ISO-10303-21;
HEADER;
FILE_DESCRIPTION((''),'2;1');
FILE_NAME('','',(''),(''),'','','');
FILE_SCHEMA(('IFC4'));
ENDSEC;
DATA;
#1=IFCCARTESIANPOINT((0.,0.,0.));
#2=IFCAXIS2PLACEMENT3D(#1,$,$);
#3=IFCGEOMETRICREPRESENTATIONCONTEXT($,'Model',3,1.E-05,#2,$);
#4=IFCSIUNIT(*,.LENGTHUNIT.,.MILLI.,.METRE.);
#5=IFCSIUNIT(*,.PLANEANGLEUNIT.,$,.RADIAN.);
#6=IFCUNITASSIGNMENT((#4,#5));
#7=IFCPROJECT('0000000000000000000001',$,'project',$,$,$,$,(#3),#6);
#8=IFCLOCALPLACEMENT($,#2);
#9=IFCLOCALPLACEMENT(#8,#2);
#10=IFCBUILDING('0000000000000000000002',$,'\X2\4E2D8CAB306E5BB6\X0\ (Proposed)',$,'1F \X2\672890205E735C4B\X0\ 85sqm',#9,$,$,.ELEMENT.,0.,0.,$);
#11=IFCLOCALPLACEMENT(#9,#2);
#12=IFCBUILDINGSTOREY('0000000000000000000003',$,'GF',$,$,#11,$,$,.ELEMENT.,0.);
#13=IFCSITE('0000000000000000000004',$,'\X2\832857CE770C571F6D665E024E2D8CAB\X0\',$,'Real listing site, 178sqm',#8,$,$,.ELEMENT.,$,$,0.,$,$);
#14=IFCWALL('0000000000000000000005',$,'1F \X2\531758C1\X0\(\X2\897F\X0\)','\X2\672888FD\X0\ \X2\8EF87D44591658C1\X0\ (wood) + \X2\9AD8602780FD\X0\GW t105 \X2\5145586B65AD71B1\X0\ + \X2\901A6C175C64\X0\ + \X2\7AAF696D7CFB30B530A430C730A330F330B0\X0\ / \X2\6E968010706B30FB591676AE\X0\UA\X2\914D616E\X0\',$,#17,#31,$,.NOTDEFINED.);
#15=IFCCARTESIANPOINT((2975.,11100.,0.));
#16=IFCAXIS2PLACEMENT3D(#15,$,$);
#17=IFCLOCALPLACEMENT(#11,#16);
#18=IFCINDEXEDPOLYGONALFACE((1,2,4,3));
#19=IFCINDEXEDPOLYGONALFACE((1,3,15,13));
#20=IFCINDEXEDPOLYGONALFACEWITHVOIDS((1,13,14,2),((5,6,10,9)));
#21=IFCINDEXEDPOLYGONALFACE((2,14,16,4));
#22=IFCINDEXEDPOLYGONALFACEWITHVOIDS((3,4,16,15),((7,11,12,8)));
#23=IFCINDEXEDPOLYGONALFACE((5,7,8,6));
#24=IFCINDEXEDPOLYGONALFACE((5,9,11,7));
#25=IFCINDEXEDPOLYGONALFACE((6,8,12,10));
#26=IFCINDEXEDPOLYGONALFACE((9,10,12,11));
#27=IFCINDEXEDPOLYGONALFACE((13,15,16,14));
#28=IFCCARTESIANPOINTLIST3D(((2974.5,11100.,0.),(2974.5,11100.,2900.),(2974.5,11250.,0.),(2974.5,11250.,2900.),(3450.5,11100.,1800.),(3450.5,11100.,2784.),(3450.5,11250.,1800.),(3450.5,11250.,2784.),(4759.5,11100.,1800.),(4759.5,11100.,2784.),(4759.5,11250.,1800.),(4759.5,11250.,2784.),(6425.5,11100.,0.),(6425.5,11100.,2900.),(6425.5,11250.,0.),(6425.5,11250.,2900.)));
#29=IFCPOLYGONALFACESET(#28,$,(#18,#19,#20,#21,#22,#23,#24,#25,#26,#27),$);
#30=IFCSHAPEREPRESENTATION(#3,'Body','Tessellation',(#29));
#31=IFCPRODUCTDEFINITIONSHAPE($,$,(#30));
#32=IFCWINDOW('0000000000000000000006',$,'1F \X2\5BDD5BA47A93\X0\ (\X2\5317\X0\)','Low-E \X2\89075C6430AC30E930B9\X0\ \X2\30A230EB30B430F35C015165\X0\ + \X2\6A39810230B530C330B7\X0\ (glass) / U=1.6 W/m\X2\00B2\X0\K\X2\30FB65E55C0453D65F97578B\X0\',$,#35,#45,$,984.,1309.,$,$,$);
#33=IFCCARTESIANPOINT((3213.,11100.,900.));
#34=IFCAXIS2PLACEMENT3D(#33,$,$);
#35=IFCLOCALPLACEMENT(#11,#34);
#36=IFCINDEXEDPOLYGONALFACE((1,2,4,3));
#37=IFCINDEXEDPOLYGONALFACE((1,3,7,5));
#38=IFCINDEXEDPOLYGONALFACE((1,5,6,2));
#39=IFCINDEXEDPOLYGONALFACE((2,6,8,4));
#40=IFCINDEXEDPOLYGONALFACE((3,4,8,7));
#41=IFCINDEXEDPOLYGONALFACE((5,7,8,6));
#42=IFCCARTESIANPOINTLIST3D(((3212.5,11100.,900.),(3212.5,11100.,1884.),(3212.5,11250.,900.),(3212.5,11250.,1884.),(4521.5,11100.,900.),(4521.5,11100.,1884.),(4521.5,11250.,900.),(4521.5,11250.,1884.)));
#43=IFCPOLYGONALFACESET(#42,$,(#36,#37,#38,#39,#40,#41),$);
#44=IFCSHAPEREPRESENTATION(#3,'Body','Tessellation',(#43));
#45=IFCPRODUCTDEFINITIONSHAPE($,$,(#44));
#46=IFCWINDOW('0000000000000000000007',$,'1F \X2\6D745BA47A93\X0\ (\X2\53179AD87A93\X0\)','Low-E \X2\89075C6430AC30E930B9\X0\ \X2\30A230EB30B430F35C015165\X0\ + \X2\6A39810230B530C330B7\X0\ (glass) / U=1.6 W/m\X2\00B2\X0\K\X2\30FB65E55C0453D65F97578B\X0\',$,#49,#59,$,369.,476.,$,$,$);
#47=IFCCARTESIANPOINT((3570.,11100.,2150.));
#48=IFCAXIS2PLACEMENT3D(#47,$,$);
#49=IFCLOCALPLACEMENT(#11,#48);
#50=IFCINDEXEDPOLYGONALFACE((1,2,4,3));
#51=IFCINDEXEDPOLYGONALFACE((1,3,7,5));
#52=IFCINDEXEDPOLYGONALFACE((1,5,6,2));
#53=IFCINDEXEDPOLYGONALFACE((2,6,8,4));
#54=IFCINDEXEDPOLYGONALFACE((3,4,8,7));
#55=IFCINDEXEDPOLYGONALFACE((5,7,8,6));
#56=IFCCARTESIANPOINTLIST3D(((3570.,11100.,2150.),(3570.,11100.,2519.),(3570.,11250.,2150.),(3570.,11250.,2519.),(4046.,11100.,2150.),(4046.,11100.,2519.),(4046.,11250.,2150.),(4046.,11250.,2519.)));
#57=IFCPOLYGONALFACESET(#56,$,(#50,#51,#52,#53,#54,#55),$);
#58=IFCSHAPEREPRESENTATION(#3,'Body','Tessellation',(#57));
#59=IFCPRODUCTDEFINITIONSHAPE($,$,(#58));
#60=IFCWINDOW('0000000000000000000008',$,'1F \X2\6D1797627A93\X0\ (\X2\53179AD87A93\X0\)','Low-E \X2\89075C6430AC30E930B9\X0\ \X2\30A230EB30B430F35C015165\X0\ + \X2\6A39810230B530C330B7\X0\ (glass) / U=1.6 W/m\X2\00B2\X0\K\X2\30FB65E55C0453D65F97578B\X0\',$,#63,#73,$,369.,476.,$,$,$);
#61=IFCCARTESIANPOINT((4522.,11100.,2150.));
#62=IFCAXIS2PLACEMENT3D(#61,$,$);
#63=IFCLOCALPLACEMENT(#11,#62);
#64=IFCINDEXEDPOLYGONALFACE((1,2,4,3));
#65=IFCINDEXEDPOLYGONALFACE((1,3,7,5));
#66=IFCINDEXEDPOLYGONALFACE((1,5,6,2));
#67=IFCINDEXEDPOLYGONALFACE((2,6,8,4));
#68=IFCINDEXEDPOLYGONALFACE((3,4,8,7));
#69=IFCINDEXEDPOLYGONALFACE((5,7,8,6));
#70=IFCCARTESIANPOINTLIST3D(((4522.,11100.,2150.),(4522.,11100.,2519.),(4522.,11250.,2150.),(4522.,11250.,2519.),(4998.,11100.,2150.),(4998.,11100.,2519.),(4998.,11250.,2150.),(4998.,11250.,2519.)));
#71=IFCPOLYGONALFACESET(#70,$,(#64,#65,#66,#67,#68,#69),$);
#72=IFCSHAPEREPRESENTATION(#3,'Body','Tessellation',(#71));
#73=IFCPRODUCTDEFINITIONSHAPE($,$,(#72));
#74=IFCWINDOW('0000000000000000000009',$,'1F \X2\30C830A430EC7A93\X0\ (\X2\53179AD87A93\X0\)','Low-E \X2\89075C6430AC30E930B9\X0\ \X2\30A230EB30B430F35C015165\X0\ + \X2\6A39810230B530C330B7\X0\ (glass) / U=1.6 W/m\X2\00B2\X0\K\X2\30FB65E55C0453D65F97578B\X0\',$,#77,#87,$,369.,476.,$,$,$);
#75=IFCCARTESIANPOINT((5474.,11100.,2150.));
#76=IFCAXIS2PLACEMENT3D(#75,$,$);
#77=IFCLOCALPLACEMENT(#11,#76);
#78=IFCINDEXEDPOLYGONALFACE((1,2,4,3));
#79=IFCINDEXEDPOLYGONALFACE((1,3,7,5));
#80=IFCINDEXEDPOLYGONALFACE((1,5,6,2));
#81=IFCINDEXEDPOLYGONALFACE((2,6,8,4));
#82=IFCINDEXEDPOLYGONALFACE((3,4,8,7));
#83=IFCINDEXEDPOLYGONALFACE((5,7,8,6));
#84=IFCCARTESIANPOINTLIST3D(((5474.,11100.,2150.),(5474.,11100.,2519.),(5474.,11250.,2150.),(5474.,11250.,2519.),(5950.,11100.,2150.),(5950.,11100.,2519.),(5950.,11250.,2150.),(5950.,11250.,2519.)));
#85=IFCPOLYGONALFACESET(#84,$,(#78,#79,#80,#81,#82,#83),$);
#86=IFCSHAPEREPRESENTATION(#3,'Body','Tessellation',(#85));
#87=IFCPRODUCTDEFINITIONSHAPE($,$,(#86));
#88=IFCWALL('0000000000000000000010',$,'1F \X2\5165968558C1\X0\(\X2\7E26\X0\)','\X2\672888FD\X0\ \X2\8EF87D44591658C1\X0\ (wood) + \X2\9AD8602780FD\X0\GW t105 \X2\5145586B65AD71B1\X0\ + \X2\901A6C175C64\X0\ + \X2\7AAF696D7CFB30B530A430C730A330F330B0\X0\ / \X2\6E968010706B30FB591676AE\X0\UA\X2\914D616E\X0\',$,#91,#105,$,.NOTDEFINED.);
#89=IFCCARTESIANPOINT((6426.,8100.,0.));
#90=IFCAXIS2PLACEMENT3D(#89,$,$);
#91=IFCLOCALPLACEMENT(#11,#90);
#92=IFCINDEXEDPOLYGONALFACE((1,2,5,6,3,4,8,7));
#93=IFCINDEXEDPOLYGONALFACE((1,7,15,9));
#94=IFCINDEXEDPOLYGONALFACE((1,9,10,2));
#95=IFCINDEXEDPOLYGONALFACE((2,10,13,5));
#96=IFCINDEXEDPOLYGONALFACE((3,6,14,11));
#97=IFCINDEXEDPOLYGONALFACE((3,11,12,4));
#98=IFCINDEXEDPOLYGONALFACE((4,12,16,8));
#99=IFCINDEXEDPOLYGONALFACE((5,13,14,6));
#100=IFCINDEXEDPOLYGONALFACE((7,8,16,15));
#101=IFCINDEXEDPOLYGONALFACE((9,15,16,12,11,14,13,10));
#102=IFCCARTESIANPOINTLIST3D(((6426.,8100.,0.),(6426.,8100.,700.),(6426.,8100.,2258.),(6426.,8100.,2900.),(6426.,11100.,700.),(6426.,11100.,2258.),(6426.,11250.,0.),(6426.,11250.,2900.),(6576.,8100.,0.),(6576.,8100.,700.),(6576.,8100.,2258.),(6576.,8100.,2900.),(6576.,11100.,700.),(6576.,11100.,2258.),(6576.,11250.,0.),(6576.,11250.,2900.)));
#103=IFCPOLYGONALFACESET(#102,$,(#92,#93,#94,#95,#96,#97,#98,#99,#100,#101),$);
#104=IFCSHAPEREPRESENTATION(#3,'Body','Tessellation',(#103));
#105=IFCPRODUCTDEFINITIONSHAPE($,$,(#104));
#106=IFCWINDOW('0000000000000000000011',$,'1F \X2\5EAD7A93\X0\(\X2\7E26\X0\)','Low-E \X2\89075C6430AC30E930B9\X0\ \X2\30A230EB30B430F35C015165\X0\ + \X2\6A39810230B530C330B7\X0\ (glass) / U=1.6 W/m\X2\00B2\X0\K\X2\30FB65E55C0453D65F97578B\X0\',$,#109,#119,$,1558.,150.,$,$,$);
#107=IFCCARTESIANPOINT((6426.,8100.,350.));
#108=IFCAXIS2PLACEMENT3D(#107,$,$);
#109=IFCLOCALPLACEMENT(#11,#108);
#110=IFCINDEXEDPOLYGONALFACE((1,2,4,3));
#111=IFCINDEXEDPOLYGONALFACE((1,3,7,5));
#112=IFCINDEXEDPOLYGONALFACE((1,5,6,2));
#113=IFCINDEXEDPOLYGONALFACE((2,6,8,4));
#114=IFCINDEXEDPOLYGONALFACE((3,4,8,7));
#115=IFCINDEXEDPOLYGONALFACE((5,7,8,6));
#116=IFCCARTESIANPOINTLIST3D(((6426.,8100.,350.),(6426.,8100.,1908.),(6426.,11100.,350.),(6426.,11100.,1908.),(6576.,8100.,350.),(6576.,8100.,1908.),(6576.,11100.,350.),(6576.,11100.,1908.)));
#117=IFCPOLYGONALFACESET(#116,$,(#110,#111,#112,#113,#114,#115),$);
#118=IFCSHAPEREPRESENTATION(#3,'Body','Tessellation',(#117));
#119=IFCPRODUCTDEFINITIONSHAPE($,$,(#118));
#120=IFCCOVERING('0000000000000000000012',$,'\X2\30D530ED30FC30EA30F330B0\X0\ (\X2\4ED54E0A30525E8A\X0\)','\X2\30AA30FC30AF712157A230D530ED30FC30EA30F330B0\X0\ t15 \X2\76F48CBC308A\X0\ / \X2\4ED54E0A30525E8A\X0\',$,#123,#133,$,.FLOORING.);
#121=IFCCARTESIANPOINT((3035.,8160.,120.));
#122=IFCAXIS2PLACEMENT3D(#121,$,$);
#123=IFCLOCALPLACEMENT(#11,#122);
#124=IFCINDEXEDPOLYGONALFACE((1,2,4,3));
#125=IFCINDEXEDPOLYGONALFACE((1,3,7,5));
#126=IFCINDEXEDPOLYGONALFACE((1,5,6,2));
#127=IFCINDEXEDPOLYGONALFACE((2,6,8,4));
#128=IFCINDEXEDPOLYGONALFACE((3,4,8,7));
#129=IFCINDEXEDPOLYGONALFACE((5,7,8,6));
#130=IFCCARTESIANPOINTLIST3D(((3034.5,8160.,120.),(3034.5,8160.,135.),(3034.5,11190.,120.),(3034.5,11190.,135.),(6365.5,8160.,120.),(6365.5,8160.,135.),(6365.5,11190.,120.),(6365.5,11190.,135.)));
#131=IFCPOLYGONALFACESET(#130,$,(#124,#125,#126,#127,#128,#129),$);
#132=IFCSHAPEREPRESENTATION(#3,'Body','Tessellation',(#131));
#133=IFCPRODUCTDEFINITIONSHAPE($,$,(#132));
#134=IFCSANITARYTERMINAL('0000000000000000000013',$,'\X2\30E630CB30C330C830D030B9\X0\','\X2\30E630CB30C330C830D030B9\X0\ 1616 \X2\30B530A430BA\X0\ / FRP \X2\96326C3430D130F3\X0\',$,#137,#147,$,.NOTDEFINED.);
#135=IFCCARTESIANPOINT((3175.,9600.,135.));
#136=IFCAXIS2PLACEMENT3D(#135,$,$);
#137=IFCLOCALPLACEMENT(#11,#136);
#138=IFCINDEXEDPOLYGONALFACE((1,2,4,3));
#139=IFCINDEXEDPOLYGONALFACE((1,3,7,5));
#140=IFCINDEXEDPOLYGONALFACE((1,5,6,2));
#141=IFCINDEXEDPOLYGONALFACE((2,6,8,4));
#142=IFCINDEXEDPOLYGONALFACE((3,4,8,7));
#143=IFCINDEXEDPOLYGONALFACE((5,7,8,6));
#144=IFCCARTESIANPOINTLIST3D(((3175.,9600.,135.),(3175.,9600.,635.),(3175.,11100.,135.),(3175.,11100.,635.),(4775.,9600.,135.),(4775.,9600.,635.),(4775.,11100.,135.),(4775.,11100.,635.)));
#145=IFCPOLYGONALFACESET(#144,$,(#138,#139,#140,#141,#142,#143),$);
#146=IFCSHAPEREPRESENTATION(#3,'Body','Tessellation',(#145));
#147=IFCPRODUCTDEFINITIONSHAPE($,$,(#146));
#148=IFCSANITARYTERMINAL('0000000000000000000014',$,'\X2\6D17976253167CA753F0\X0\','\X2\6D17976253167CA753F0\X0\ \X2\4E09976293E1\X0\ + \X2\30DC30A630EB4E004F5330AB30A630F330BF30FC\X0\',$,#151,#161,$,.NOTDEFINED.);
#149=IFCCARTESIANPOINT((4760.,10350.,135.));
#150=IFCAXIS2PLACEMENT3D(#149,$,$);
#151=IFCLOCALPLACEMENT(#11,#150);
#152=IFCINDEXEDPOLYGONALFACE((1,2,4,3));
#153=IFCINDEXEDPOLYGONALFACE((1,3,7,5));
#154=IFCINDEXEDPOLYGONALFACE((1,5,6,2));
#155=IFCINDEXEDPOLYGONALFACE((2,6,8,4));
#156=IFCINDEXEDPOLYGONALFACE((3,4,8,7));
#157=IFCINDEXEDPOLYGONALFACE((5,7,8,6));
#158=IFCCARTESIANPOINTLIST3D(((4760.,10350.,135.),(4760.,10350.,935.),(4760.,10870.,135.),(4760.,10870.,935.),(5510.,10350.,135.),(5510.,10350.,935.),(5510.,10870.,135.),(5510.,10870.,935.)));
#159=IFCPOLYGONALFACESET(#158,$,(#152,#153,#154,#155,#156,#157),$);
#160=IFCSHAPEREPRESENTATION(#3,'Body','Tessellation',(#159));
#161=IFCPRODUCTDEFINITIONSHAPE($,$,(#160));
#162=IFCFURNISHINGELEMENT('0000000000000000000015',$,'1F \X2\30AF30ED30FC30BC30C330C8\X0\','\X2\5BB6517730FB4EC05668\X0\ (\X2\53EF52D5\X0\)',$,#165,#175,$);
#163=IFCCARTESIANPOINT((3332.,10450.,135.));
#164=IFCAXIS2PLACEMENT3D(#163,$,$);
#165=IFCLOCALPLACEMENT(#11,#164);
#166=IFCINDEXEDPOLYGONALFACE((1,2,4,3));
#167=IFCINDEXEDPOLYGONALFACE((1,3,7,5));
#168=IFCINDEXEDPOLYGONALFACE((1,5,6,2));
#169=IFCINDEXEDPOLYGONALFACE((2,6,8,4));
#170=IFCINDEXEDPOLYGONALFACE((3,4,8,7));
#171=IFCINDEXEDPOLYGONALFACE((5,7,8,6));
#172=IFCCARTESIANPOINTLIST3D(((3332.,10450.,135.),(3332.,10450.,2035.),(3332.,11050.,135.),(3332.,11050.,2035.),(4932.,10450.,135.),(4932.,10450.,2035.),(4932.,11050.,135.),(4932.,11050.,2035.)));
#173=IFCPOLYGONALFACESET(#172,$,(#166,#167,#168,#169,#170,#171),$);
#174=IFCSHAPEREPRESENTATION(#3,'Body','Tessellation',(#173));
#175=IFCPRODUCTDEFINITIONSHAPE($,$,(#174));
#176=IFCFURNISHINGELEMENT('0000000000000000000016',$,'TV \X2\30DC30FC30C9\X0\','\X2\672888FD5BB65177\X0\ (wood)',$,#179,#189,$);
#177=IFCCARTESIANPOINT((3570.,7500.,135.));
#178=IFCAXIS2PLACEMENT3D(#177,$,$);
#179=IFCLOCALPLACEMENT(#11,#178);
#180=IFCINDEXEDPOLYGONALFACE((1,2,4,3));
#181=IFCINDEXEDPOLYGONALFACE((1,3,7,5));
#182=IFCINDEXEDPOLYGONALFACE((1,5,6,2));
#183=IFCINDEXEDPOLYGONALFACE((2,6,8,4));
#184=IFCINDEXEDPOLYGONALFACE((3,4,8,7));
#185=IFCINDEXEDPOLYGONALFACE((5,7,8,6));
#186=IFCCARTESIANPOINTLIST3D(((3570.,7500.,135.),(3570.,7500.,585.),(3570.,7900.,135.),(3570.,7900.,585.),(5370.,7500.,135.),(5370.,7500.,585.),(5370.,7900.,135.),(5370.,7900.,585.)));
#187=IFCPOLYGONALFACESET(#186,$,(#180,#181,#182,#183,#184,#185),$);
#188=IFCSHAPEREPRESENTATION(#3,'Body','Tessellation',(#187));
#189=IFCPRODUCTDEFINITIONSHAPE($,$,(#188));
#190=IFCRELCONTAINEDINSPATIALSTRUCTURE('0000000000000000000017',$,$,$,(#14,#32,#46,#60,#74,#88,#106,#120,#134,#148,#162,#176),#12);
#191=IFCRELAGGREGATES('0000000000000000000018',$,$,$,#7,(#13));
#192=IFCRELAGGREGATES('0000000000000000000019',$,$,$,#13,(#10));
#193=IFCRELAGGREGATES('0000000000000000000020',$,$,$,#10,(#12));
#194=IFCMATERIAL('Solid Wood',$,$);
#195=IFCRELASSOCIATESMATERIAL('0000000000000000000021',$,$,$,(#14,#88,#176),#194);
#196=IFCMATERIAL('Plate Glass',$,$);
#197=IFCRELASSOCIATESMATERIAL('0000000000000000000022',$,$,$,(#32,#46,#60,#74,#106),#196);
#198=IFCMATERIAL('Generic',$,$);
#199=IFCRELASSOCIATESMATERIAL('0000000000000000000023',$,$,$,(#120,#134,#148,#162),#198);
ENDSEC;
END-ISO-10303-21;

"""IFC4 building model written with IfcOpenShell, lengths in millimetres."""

from ifc_helpers import new_model, si_unit, frame, frame_2d, origin, place, context, project, spatial, rectangle, extrude, material, element, fill, save


model = new_model("IFC4")

# Units and contexts
model_context = context("Model", 3, precision=1e-05, world=origin())
ifc_project = project(units=[si_unit("LENGTHUNIT", "METRE", prefix="MILLI"), si_unit("PLANEANGLEUNIT", "RADIAN")], contexts=[model_context])

# Site, building, storey
site_placement = place(None, origin())
site = spatial("IfcSite", under=ifc_project, at=site_placement, Name="茨城県土浦市中貫", ObjectType="Real listing site, 178sqm", CompositionType="ELEMENT", RefElevation=0.0)
building_placement = place(site_placement, origin())
building = spatial("IfcBuilding", under=site, at=building_placement, Name="中貫の家 (Proposed)", ObjectType="1F 木造平屋 85sqm", CompositionType="ELEMENT", ElevationOfRefHeight=0.0, ElevationOfTerrain=0.0)
storey_placement = place(building_placement, origin())
storey = spatial("IfcBuildingStorey", under=building, at=storey_placement, Name="GF", CompositionType="ELEMENT", Elevation=0.0)

# Shared definitions
ifc_material_1 = material(Name="Solid Wood")

# Wall, openings, windows
wall_1_placement = place(storey_placement, frame((2975.0, 11100.0, 0.0)))
wall_1 = element("IfcWall", 1, at=wall_1_placement, inside=storey, material=ifc_material_1, Name="1F 北壁(西)", Description="木製 軸組外壁 (wood) + 高性能GW t105 充填断熱 + 通気層 + 窯業系サイディング / 準耐火・外皮UA配慮", PredefinedType="NOTDEFINED", context=model_context, shape_type="SweptSolid", body=[
    extrude(rectangle(XDim=3451.0, YDim=150.0, at=frame_2d((1725.0, 75.0))), frame((2975.0, 11100.0, 0.0)), (0.0, 0.0, 1.0), 2900.0),
])
opening_1_placement = place(storey_placement, frame((3213.0, 11100.0, 900.0)))
opening_1 = element("IfcOpeningElement", 2, at=opening_1_placement, cuts=wall_1, PredefinedType="NOTDEFINED", context=model_context, shape_type="SweptSolid", body=[
    extrude(rectangle(XDim=1309.0, YDim=150.0, at=frame_2d((654.0, 75.0))), frame((3213.0, 11100.0, 900.0)), (0.0, 0.0, 1.0), 984.0),
])
opening_2_placement = place(storey_placement, frame((3570.0, 11100.0, 2150.0)))
opening_2 = element("IfcOpeningElement", 3, at=opening_2_placement, cuts=wall_1, PredefinedType="NOTDEFINED", context=model_context, shape_type="SweptSolid", body=[
    extrude(rectangle(XDim=476.0, YDim=150.0, at=frame_2d((238.0, 75.0))), frame((3570.0, 11100.0, 2150.0)), (0.0, 0.0, 1.0), 369.0),
])
opening_3_placement = place(storey_placement, frame((4522.0, 11100.0, 2150.0)))
opening_3 = element("IfcOpeningElement", 4, at=opening_3_placement, cuts=wall_1, PredefinedType="NOTDEFINED", context=model_context, shape_type="SweptSolid", body=[
    extrude(rectangle(XDim=476.0, YDim=150.0, at=frame_2d((238.0, 75.0))), frame((4522.0, 11100.0, 2150.0)), (0.0, 0.0, 1.0), 369.0),
])
opening_4_placement = place(storey_placement, frame((5474.0, 11100.0, 2150.0)))
opening_4 = element("IfcOpeningElement", 5, at=opening_4_placement, cuts=wall_1, PredefinedType="NOTDEFINED", context=model_context, shape_type="SweptSolid", body=[
    extrude(rectangle(XDim=476.0, YDim=150.0, at=frame_2d((238.0, 75.0))), frame((5474.0, 11100.0, 2150.0)), (0.0, 0.0, 1.0), 369.0),
])
ifc_material_2 = material(Name="Plate Glass")
window_1_placement = place(storey_placement, frame((3213.0, 11100.0, 900.0)))
window_1 = element("IfcWindow", 6, at=window_1_placement, inside=storey, material=ifc_material_2, Name="1F 寝室窓 (北)", Description="Low-E 複層ガラス アルゴン封入 + 樹脂サッシ (glass) / U=1.6 W/m²K・日射取得型", OverallHeight=984.0, OverallWidth=1309.0, context=model_context, shape_type="SweptSolid", body=[
    extrude(rectangle(XDim=1309.0, YDim=150.0, at=frame_2d((654.0, 75.0))), frame((3213.0, 11100.0, 900.0)), (0.0, 0.0, 1.0), 984.0),
])
fill(opening_1, window_1)
window_2_placement = place(storey_placement, frame((3570.0, 11100.0, 2150.0)))
window_2 = element("IfcWindow", 7, at=window_2_placement, inside=storey, material=ifc_material_2, Name="1F 浴室窓 (北高窓)", Description="Low-E 複層ガラス アルゴン封入 + 樹脂サッシ (glass) / U=1.6 W/m²K・日射取得型", OverallHeight=369.0, OverallWidth=476.0, context=model_context, shape_type="SweptSolid", body=[
    extrude(rectangle(XDim=476.0, YDim=150.0, at=frame_2d((238.0, 75.0))), frame((3570.0, 11100.0, 2150.0)), (0.0, 0.0, 1.0), 369.0),
])
fill(opening_2, window_2)
window_3_placement = place(storey_placement, frame((4522.0, 11100.0, 2150.0)))
window_3 = element("IfcWindow", 8, at=window_3_placement, inside=storey, material=ifc_material_2, Name="1F 洗面窓 (北高窓)", Description="Low-E 複層ガラス アルゴン封入 + 樹脂サッシ (glass) / U=1.6 W/m²K・日射取得型", OverallHeight=369.0, OverallWidth=476.0, context=model_context, shape_type="SweptSolid", body=[
    extrude(rectangle(XDim=476.0, YDim=150.0, at=frame_2d((238.0, 75.0))), frame((4522.0, 11100.0, 2150.0)), (0.0, 0.0, 1.0), 369.0),
])
fill(opening_3, window_3)
window_4_placement = place(storey_placement, frame((5474.0, 11100.0, 2150.0)))
window_4 = element("IfcWindow", 9, at=window_4_placement, inside=storey, material=ifc_material_2, Name="1F トイレ窓 (北高窓)", Description="Low-E 複層ガラス アルゴン封入 + 樹脂サッシ (glass) / U=1.6 W/m²K・日射取得型", OverallHeight=369.0, OverallWidth=476.0, context=model_context, shape_type="SweptSolid", body=[
    extrude(rectangle(XDim=476.0, YDim=150.0, at=frame_2d((238.0, 75.0))), frame((5474.0, 11100.0, 2150.0)), (0.0, 0.0, 1.0), 369.0),
])
fill(opening_4, window_4)

# Wall, opening, window
wall_2_placement = place(storey_placement, frame((6426.0, 8100.0, 0.0)))
wall_2 = element("IfcWall", 10, at=wall_2_placement, inside=storey, material=ifc_material_1, Name="1F 入隅壁(縦)", Description="木製 軸組外壁 (wood) + 高性能GW t105 充填断熱 + 通気層 + 窯業系サイディング / 準耐火・外皮UA配慮", PredefinedType="NOTDEFINED", context=model_context, shape_type="SweptSolid", body=[
    extrude(rectangle(XDim=150.0, YDim=3150.0, at=frame_2d((75.0, 1575.0))), frame((6426.0, 8100.0, 0.0)), (0.0, 0.0, 1.0), 2900.0),
])
opening_5_placement = place(storey_placement, frame((6426.0, 8100.0, 350.0)))
opening_5 = element("IfcOpeningElement", 11, at=opening_5_placement, cuts=wall_2, PredefinedType="NOTDEFINED", context=model_context, shape_type="SweptSolid", body=[
    extrude(rectangle(XDim=150.0, YDim=3000.0, at=frame_2d((75.0, 1500.0))), frame((6426.0, 8100.0, 350.0)), (0.0, 0.0, 1.0), 1558.0),
])
window_5_placement = place(storey_placement, frame((6426.0, 8100.0, 350.0)))
window_5 = element("IfcWindow", 12, at=window_5_placement, inside=storey, material=ifc_material_2, Name="1F 庭窓(縦)", Description="Low-E 複層ガラス アルゴン封入 + 樹脂サッシ (glass) / U=1.6 W/m²K・日射取得型", OverallHeight=1558.0, OverallWidth=150.0, context=model_context, shape_type="SweptSolid", body=[
    extrude(rectangle(XDim=150.0, YDim=3000.0, at=frame_2d((75.0, 1500.0))), frame((6426.0, 8100.0, 350.0)), (0.0, 0.0, 1.0), 1558.0),
])
fill(opening_5, window_5)

# Covering
ifc_material_3 = material(Name="Generic")
covering_placement = place(storey_placement, frame((3035.0, 8160.0, 120.0)))
element("IfcCovering", 13, at=covering_placement, inside=storey, material=ifc_material_3, Name="フローリング (仕上げ床)", Description="オーク無垢フローリング t15 直貼り / 仕上げ床", PredefinedType="FLOORING", context=model_context, shape_type="SweptSolid", body=[
    extrude(rectangle(XDim=3331.0, YDim=3030.0, at=frame_2d((1665.0, 1515.0))), frame((3035.0, 8160.0, 120.0)), (0.0, 0.0, 1.0), 15.0),
])

# Sanitary terminals
sanitary_terminal_1_placement = place(storey_placement, frame((3175.0, 9600.0, 135.0)))
element("IfcSanitaryTerminal", 14, at=sanitary_terminal_1_placement, inside=storey, material=ifc_material_3, Name="ユニットバス", Description="ユニットバス 1616 サイズ / FRP 防水パン", PredefinedType="NOTDEFINED", context=model_context, shape_type="SweptSolid", body=[
    extrude(rectangle(XDim=1600.0, YDim=1500.0, at=frame_2d((800.0, 750.0))), frame((3175.0, 9600.0, 135.0)), (0.0, 0.0, 1.0), 500.0),
])
sanitary_terminal_2_placement = place(storey_placement, frame((4760.0, 10350.0, 135.0)))
element("IfcSanitaryTerminal", 15, at=sanitary_terminal_2_placement, inside=storey, material=ifc_material_3, Name="洗面化粧台", Description="洗面化粧台 三面鏡 + ボウル一体カウンター", PredefinedType="NOTDEFINED", context=model_context, shape_type="SweptSolid", body=[
    extrude(rectangle(XDim=750.0, YDim=520.0, at=frame_2d((375.0, 260.0))), frame((4760.0, 10350.0, 135.0)), (0.0, 0.0, 1.0), 800.0),
])

# Furnishing elements
furnishing_1_placement = place(storey_placement, frame((3332.0, 10450.0, 135.0)))
element("IfcFurnishingElement", 16, at=furnishing_1_placement, inside=storey, material=ifc_material_3, Name="1F クローゼット", Description="家具・什器 (可動)", context=model_context, shape_type="SweptSolid", body=[
    extrude(rectangle(XDim=1600.0, YDim=600.0, at=frame_2d((800.0, 300.0))), frame((3332.0, 10450.0, 135.0)), (0.0, 0.0, 1.0), 1900.0),
])
furnishing_2_placement = place(storey_placement, frame((3570.0, 7500.0, 135.0)))
element("IfcFurnishingElement", 17, at=furnishing_2_placement, inside=storey, material=ifc_material_1, Name="TV ボード", Description="木製家具 (wood)", context=model_context, shape_type="SweptSolid", body=[
    extrude(rectangle(XDim=1800.0, YDim=400.0, at=frame_2d((900.0, 200.0))), frame((3570.0, 7500.0, 135.0)), (0.0, 0.0, 1.0), 450.0),
])

save(model, "model.ifc")
